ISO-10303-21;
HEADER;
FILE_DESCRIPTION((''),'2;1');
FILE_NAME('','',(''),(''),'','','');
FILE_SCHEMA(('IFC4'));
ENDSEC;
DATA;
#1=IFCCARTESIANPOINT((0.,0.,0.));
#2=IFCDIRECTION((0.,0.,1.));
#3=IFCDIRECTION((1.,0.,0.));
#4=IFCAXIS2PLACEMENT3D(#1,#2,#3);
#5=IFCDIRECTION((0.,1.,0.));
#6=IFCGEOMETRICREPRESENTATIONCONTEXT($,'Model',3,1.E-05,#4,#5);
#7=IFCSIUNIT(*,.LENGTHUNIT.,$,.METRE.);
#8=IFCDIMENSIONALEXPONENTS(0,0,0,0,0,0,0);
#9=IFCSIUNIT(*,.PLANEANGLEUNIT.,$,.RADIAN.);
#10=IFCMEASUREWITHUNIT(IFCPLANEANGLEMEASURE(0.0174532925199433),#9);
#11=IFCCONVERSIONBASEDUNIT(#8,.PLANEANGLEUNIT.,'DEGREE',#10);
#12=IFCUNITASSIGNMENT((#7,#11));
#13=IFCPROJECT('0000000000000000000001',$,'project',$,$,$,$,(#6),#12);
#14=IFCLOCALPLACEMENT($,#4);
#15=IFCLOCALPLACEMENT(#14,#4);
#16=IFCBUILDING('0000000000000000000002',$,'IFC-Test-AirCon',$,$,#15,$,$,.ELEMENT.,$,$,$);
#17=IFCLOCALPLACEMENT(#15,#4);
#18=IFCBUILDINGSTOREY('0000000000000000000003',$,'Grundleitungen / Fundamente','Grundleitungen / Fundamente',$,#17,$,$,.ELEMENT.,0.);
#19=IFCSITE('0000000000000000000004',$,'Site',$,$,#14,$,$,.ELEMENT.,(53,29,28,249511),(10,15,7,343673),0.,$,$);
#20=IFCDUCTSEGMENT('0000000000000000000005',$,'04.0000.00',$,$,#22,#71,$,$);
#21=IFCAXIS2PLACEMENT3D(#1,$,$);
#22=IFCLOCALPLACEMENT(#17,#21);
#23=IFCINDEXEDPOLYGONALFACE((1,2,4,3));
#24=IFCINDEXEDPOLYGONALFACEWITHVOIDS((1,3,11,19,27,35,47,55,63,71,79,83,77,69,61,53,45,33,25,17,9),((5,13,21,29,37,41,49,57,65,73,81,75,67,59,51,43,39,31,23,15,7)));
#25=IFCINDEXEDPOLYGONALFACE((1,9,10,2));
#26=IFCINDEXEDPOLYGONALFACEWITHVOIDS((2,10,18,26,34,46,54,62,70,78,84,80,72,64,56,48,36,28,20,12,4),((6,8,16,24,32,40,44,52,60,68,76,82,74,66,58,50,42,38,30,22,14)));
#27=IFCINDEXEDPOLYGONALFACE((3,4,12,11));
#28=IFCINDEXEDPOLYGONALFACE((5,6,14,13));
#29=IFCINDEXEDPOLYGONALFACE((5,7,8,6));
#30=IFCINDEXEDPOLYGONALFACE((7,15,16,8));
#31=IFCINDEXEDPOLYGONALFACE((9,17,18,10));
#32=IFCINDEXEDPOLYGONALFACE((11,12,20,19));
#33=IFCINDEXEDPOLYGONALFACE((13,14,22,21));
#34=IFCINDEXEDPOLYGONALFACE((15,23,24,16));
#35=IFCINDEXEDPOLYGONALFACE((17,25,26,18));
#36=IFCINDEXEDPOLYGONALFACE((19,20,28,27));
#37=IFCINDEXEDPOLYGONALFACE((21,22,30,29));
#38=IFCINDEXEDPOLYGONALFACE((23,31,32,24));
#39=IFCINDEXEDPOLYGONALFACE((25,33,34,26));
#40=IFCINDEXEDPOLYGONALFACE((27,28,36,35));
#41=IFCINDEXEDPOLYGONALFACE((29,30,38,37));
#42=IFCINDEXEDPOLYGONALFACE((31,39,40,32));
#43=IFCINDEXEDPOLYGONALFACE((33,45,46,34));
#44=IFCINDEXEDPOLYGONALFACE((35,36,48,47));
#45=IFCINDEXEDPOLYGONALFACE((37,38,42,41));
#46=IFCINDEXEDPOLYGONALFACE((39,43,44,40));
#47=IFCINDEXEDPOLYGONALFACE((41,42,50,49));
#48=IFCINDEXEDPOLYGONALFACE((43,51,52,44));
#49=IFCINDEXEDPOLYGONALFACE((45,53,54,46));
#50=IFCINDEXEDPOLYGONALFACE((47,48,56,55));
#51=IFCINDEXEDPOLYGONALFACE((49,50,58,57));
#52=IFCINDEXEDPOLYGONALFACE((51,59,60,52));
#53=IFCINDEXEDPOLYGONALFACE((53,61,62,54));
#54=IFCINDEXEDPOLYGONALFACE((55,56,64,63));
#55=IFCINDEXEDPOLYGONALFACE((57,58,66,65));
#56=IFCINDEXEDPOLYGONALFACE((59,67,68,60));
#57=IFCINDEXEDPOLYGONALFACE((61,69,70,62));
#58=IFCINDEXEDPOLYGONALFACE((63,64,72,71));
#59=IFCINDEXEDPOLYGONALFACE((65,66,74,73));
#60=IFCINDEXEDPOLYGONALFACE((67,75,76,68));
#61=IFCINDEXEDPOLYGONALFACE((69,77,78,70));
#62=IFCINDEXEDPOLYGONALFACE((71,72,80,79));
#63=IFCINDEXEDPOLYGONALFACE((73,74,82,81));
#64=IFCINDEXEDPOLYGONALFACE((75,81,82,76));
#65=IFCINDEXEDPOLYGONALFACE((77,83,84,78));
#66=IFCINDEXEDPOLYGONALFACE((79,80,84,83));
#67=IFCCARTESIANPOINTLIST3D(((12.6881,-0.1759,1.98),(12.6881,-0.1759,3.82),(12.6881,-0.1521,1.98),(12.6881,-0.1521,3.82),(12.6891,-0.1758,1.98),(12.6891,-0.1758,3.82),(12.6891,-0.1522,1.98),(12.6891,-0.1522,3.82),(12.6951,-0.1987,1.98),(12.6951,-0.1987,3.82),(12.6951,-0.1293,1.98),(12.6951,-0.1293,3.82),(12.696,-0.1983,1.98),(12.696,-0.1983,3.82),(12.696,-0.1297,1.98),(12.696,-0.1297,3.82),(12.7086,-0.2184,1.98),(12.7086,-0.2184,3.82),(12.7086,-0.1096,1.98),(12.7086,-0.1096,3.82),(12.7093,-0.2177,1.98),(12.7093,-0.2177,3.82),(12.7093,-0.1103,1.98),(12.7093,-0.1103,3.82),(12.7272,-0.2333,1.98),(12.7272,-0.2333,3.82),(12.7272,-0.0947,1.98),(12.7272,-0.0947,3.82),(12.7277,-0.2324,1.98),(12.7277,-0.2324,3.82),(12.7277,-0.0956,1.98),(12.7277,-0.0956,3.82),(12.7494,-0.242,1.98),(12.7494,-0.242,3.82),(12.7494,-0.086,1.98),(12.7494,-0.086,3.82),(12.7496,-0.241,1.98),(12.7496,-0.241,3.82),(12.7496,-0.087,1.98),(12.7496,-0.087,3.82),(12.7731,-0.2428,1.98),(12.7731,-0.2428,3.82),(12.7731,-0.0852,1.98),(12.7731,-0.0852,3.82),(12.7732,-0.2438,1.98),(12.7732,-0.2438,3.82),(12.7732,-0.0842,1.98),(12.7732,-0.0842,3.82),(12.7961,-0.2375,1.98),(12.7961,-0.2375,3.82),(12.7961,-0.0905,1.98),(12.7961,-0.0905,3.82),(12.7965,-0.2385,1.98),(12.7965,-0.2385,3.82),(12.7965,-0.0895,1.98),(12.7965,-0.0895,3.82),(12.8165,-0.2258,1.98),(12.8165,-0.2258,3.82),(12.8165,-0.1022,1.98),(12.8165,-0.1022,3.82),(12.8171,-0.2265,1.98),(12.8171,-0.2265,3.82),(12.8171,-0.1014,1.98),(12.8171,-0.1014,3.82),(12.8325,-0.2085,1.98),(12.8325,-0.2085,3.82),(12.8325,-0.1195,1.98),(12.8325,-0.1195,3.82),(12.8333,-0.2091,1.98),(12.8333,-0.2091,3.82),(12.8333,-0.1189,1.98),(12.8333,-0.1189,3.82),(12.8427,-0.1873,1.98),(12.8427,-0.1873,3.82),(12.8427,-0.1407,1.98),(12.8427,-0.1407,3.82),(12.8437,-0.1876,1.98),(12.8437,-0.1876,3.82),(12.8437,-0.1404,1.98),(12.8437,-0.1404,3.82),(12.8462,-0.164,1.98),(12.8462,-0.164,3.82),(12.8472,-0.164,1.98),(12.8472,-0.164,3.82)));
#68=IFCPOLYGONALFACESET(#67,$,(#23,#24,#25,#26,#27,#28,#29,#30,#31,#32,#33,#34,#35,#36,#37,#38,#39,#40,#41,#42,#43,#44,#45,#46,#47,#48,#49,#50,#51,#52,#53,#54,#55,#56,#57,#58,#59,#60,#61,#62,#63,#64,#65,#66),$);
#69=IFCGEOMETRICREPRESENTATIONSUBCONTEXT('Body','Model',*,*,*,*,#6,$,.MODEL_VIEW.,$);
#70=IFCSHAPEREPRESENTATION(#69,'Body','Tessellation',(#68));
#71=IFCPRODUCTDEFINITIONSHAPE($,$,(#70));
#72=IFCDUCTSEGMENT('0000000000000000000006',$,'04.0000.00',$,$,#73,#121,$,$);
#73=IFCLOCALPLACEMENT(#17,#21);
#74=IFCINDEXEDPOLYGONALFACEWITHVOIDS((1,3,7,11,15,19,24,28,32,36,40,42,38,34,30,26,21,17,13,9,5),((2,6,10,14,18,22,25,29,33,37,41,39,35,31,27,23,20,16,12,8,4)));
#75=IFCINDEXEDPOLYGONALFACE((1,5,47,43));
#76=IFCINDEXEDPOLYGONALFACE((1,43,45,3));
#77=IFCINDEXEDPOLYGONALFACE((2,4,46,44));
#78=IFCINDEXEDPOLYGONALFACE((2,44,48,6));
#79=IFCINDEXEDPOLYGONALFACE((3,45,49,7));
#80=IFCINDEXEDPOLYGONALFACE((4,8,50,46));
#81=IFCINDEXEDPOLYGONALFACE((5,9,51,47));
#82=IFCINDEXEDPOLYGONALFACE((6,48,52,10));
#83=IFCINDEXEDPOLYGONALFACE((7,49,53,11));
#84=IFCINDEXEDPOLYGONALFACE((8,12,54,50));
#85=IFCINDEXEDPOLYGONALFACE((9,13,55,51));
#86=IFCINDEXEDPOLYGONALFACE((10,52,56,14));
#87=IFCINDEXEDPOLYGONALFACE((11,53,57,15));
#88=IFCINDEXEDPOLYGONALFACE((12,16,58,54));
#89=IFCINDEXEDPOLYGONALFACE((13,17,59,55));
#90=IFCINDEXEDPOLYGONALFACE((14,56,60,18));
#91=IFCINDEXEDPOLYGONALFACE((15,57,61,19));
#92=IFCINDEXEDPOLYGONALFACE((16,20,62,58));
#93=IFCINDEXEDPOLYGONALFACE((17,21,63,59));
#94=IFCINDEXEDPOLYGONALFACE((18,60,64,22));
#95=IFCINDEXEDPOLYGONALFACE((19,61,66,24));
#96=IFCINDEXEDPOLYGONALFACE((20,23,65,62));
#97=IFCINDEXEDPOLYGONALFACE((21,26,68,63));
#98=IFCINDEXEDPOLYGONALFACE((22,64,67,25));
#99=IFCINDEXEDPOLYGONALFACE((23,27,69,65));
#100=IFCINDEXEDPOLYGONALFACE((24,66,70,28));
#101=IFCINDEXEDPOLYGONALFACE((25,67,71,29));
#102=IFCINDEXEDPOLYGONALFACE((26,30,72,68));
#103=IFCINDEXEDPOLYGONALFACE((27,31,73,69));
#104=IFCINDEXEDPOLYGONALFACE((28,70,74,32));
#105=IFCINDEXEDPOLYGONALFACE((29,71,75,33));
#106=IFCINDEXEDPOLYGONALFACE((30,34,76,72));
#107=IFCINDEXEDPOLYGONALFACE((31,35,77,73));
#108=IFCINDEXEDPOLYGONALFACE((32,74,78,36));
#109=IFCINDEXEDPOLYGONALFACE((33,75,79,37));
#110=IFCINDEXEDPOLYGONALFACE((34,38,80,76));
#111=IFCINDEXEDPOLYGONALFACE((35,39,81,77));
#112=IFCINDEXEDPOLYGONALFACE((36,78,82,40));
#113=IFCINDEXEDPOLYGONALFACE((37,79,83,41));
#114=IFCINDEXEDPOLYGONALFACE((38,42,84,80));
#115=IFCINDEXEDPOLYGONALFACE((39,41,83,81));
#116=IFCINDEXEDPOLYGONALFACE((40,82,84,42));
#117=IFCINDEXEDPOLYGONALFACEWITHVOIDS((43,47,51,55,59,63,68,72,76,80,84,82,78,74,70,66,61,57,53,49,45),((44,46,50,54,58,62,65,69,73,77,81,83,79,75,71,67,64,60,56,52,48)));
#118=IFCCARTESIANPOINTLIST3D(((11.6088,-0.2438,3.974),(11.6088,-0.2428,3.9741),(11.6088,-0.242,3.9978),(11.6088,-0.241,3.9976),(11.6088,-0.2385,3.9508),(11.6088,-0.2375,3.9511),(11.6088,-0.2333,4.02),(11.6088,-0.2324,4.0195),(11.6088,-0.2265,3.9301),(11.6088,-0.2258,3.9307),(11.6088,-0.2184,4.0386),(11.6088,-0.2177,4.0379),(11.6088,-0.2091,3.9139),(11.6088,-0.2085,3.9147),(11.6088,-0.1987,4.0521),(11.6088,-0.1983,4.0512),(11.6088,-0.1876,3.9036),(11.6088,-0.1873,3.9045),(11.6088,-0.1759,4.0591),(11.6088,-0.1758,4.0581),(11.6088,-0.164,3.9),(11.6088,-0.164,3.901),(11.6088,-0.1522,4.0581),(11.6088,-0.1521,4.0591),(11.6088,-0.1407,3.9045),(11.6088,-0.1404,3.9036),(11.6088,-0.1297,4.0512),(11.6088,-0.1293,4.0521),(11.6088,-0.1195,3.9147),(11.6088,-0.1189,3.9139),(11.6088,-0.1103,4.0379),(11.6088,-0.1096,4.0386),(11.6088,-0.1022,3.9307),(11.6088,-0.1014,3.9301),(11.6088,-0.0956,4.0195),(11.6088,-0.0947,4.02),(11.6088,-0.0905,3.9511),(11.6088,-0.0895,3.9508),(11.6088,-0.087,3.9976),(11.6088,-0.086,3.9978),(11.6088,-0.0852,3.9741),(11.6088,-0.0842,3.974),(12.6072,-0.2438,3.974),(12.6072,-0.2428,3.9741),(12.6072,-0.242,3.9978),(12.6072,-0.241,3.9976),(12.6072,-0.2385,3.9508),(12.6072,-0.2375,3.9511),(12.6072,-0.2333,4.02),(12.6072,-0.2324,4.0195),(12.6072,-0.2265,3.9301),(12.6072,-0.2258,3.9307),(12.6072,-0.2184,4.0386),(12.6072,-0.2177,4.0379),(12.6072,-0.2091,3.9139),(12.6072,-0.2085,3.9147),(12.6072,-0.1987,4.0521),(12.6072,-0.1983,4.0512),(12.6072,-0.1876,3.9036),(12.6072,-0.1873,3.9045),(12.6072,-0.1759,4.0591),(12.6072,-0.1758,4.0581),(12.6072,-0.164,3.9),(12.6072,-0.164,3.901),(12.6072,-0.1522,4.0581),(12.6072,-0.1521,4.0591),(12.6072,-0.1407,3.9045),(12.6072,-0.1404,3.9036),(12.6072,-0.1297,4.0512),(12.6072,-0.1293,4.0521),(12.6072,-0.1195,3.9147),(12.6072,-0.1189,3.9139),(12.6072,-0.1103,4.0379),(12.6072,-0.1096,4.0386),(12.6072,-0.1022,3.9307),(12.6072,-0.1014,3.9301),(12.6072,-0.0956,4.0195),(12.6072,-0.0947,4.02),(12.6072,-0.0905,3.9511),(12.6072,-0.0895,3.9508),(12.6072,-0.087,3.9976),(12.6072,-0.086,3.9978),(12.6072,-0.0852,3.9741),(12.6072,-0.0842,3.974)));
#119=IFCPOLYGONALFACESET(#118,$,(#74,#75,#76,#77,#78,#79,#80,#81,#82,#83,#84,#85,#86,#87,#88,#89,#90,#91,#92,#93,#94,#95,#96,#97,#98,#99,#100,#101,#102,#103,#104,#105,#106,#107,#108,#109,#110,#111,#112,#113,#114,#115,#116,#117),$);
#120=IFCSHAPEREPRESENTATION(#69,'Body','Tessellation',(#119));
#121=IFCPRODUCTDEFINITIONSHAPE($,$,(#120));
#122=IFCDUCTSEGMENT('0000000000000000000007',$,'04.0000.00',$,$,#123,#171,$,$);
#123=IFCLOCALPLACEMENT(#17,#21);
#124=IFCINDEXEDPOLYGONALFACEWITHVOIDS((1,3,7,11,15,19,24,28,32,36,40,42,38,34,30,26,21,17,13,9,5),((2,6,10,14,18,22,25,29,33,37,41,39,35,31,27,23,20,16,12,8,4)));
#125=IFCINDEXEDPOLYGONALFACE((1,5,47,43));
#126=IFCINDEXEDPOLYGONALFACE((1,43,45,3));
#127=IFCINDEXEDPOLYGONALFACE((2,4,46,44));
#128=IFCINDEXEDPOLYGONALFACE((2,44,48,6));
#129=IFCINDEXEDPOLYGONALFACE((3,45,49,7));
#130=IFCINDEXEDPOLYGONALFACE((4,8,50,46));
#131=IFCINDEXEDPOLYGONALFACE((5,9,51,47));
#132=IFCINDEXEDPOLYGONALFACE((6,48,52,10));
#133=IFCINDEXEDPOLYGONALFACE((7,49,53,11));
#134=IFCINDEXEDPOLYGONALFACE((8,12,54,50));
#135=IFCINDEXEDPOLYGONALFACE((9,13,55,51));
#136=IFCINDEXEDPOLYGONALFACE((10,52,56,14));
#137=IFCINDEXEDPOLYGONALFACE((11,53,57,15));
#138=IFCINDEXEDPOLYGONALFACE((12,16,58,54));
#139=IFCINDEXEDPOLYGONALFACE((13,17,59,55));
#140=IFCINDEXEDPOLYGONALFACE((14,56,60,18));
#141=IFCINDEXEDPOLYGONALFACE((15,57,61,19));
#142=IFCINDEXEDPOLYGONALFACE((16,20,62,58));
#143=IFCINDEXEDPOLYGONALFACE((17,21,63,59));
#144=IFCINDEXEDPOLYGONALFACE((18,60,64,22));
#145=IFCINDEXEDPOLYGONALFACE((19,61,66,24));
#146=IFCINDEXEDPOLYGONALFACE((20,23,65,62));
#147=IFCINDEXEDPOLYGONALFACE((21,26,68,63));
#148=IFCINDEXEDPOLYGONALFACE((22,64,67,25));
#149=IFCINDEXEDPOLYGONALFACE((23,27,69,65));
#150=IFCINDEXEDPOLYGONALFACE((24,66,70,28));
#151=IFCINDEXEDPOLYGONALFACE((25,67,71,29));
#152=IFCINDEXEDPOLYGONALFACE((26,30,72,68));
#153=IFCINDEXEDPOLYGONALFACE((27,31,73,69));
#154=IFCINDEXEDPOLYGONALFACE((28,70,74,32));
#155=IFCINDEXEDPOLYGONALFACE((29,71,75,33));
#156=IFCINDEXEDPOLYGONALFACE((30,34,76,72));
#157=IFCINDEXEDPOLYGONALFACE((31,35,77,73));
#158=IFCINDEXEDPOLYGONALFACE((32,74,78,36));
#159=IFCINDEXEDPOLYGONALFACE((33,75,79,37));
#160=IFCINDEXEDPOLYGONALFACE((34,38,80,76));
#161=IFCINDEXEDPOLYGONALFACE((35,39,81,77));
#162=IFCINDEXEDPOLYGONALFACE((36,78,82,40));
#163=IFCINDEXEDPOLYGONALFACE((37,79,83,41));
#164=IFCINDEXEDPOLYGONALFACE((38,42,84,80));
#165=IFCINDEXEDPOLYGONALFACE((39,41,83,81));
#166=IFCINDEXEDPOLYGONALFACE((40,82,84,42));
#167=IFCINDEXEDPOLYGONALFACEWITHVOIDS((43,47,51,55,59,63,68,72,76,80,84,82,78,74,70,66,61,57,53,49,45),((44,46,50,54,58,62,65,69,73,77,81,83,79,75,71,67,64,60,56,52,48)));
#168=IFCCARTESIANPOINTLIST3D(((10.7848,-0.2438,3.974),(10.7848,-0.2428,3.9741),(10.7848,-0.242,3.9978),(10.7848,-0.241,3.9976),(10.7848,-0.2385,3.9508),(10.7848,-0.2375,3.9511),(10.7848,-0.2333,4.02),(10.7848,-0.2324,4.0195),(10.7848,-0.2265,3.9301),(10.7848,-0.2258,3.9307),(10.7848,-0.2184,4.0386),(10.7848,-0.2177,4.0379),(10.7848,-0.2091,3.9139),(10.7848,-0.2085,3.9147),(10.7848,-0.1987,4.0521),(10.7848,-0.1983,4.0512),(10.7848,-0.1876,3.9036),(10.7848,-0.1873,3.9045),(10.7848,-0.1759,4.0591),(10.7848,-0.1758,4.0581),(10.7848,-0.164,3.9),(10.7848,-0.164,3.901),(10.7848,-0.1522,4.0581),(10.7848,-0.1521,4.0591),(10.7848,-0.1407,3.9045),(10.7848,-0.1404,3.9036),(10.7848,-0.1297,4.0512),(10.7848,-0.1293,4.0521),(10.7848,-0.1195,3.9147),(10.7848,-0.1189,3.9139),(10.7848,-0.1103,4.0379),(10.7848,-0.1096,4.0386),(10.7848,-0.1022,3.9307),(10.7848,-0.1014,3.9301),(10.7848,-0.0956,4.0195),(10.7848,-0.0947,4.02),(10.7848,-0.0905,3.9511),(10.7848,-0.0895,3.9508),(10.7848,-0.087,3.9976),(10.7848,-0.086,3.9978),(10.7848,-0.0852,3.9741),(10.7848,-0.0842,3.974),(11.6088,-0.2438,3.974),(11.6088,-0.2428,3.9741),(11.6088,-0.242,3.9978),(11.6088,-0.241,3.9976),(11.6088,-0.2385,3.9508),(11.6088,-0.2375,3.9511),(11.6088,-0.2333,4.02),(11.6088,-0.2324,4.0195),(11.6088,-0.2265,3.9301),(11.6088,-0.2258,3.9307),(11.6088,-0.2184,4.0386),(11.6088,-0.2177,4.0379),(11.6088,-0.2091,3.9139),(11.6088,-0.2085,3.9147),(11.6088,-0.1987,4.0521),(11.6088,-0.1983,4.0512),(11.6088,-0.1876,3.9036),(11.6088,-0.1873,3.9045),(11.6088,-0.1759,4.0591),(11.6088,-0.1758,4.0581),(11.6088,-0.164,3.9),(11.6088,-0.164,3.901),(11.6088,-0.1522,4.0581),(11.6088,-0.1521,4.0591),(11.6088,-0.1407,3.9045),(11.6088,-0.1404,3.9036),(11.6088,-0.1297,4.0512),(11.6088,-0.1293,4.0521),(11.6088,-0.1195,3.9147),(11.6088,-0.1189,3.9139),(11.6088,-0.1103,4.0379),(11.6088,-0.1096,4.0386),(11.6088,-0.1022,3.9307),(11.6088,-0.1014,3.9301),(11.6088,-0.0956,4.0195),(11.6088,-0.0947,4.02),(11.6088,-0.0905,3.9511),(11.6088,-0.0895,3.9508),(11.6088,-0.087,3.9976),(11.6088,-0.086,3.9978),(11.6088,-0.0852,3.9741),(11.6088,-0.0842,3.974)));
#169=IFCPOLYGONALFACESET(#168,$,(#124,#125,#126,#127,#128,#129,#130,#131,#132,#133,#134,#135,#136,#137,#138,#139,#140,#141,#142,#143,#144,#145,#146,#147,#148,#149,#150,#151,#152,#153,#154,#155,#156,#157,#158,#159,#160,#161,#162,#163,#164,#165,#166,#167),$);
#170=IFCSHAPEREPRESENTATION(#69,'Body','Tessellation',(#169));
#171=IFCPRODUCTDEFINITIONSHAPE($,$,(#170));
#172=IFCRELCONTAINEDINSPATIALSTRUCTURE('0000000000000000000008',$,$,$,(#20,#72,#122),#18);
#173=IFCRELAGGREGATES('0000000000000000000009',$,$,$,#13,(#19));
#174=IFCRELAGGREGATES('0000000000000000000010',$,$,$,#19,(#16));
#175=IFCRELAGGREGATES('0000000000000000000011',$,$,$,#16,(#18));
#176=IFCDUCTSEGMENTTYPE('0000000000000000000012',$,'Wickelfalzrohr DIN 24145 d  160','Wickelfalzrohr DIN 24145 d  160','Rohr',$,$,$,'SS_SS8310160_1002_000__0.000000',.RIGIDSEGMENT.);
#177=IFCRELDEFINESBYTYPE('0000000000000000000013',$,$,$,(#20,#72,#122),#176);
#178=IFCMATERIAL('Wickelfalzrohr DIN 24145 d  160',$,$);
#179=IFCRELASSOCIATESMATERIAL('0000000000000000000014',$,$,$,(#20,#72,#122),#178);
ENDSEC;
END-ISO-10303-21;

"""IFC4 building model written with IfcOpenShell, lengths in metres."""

from ifc_helpers import new_model, entity, si_unit, converted_unit, direction, frame, origin_with_axes, origin_2d_with_axis, place, context, subcontext, project, spatial, hollow_circle, extrude, material, type_object, element, save


model = new_model("IFC4")

# Units and contexts
model_context = context("Model", 3, precision=1e-05, world=origin_with_axes(), true_north=direction((0.0, 1.0, 0.0)))
body_context = subcontext(model_context, "Body", "Model", "MODEL_VIEW")
ifc_project = project(units=[si_unit("LENGTHUNIT", "METRE"), converted_unit("PLANEANGLEUNIT", "DEGREE", entity("IfcPlaneAngleMeasure", 0.0174532925199433), si_unit("PLANEANGLEUNIT", "RADIAN"), dimensions=[0, 0, 0, 0, 0, 0, 0])], contexts=[model_context])

# Site, building, storey
site_placement = place(None, origin_with_axes())
site = spatial("IfcSite", under=ifc_project, at=site_placement, Name="Site", CompositionType="ELEMENT", RefLatitude=(53, 29, 28, 249511), RefLongitude=(10, 15, 7, 343673), RefElevation=0.0)
building_placement = place(site_placement, origin_with_axes())
building = spatial("IfcBuilding", under=site, at=building_placement, Name="IFC-Test-AirCon", CompositionType="ELEMENT")
storey_placement = place(building_placement, origin_with_axes())
storey = spatial("IfcBuildingStorey", under=building, at=storey_placement, Name="Grundleitungen / Fundamente", Description="Grundleitungen / Fundamente", CompositionType="ELEMENT", Elevation=0.0)

# Duct segments
ifc_material_1 = material(Name="Wickelfalzrohr DIN 24145 d  160")
duct_segment_type_1 = type_object("IfcDuctSegmentType", Name="Wickelfalzrohr DIN 24145 d  160", Description="Wickelfalzrohr DIN 24145 d  160", ApplicableOccurrence="Rohr", ElementType="SS_SS8310160_1002_000__0.000000", PredefinedType="RIGIDSEGMENT")
duct_segment_1_placement = place(storey_placement, frame((12.7672, -0.164, 1.98), z_axis=(-1.0, 0.0, 0.0), x_axis=(0.0, 0.0, 1.0)))
element("IfcDuctSegment", 1, at=duct_segment_1_placement, inside=storey, type_object=duct_segment_type_1, material=ifc_material_1, Name="04.0000.00", context=body_context, shape_type="SweptSolid", body=[
    extrude(hollow_circle(Radius=0.08, WallThickness=0.001, at=origin_2d_with_axis()), frame((0.0, 0.0, 0.0), z_axis=(1.0, 0.0, 0.0), x_axis=(0.0, 0.0, -1.0)), (0.0, 0.0, 1.0), 1.84),
])
duct_segment_2_placement = place(storey_placement, frame((12.6072, -0.164, 3.98), z_axis=(0.0, 0.0, 1.0), x_axis=(-1.0, 0.0, 0.0)))
element("IfcDuctSegment", 2, at=duct_segment_2_placement, inside=storey, type_object=duct_segment_type_1, material=ifc_material_1, Name="04.0000.00", context=body_context, shape_type="SweptSolid", body=[
    extrude(hollow_circle(Radius=0.08, WallThickness=0.001, at=origin_2d_with_axis()), frame((0.0, 0.0, 0.0), z_axis=(1.0, 0.0, 0.0), x_axis=(0.0, 0.0, -1.0)), (0.0, 0.0, 1.0), 0.9984),
])
duct_segment_3_placement = place(storey_placement, frame((11.6088, -0.164, 3.98), z_axis=(0.0, 0.0, 1.0), x_axis=(-1.0, 0.0, 0.0)))
element("IfcDuctSegment", 3, at=duct_segment_3_placement, inside=storey, type_object=duct_segment_type_1, material=ifc_material_1, Name="04.0000.00", context=body_context, shape_type="SweptSolid", body=[
    extrude(hollow_circle(Radius=0.08, WallThickness=0.001, at=origin_2d_with_axis()), frame((0.0, 0.0, 0.0), z_axis=(1.0, 0.0, 0.0), x_axis=(0.0, 0.0, -1.0)), (0.0, 0.0, 1.0), 0.824),
])

save(model, "model.ifc")
